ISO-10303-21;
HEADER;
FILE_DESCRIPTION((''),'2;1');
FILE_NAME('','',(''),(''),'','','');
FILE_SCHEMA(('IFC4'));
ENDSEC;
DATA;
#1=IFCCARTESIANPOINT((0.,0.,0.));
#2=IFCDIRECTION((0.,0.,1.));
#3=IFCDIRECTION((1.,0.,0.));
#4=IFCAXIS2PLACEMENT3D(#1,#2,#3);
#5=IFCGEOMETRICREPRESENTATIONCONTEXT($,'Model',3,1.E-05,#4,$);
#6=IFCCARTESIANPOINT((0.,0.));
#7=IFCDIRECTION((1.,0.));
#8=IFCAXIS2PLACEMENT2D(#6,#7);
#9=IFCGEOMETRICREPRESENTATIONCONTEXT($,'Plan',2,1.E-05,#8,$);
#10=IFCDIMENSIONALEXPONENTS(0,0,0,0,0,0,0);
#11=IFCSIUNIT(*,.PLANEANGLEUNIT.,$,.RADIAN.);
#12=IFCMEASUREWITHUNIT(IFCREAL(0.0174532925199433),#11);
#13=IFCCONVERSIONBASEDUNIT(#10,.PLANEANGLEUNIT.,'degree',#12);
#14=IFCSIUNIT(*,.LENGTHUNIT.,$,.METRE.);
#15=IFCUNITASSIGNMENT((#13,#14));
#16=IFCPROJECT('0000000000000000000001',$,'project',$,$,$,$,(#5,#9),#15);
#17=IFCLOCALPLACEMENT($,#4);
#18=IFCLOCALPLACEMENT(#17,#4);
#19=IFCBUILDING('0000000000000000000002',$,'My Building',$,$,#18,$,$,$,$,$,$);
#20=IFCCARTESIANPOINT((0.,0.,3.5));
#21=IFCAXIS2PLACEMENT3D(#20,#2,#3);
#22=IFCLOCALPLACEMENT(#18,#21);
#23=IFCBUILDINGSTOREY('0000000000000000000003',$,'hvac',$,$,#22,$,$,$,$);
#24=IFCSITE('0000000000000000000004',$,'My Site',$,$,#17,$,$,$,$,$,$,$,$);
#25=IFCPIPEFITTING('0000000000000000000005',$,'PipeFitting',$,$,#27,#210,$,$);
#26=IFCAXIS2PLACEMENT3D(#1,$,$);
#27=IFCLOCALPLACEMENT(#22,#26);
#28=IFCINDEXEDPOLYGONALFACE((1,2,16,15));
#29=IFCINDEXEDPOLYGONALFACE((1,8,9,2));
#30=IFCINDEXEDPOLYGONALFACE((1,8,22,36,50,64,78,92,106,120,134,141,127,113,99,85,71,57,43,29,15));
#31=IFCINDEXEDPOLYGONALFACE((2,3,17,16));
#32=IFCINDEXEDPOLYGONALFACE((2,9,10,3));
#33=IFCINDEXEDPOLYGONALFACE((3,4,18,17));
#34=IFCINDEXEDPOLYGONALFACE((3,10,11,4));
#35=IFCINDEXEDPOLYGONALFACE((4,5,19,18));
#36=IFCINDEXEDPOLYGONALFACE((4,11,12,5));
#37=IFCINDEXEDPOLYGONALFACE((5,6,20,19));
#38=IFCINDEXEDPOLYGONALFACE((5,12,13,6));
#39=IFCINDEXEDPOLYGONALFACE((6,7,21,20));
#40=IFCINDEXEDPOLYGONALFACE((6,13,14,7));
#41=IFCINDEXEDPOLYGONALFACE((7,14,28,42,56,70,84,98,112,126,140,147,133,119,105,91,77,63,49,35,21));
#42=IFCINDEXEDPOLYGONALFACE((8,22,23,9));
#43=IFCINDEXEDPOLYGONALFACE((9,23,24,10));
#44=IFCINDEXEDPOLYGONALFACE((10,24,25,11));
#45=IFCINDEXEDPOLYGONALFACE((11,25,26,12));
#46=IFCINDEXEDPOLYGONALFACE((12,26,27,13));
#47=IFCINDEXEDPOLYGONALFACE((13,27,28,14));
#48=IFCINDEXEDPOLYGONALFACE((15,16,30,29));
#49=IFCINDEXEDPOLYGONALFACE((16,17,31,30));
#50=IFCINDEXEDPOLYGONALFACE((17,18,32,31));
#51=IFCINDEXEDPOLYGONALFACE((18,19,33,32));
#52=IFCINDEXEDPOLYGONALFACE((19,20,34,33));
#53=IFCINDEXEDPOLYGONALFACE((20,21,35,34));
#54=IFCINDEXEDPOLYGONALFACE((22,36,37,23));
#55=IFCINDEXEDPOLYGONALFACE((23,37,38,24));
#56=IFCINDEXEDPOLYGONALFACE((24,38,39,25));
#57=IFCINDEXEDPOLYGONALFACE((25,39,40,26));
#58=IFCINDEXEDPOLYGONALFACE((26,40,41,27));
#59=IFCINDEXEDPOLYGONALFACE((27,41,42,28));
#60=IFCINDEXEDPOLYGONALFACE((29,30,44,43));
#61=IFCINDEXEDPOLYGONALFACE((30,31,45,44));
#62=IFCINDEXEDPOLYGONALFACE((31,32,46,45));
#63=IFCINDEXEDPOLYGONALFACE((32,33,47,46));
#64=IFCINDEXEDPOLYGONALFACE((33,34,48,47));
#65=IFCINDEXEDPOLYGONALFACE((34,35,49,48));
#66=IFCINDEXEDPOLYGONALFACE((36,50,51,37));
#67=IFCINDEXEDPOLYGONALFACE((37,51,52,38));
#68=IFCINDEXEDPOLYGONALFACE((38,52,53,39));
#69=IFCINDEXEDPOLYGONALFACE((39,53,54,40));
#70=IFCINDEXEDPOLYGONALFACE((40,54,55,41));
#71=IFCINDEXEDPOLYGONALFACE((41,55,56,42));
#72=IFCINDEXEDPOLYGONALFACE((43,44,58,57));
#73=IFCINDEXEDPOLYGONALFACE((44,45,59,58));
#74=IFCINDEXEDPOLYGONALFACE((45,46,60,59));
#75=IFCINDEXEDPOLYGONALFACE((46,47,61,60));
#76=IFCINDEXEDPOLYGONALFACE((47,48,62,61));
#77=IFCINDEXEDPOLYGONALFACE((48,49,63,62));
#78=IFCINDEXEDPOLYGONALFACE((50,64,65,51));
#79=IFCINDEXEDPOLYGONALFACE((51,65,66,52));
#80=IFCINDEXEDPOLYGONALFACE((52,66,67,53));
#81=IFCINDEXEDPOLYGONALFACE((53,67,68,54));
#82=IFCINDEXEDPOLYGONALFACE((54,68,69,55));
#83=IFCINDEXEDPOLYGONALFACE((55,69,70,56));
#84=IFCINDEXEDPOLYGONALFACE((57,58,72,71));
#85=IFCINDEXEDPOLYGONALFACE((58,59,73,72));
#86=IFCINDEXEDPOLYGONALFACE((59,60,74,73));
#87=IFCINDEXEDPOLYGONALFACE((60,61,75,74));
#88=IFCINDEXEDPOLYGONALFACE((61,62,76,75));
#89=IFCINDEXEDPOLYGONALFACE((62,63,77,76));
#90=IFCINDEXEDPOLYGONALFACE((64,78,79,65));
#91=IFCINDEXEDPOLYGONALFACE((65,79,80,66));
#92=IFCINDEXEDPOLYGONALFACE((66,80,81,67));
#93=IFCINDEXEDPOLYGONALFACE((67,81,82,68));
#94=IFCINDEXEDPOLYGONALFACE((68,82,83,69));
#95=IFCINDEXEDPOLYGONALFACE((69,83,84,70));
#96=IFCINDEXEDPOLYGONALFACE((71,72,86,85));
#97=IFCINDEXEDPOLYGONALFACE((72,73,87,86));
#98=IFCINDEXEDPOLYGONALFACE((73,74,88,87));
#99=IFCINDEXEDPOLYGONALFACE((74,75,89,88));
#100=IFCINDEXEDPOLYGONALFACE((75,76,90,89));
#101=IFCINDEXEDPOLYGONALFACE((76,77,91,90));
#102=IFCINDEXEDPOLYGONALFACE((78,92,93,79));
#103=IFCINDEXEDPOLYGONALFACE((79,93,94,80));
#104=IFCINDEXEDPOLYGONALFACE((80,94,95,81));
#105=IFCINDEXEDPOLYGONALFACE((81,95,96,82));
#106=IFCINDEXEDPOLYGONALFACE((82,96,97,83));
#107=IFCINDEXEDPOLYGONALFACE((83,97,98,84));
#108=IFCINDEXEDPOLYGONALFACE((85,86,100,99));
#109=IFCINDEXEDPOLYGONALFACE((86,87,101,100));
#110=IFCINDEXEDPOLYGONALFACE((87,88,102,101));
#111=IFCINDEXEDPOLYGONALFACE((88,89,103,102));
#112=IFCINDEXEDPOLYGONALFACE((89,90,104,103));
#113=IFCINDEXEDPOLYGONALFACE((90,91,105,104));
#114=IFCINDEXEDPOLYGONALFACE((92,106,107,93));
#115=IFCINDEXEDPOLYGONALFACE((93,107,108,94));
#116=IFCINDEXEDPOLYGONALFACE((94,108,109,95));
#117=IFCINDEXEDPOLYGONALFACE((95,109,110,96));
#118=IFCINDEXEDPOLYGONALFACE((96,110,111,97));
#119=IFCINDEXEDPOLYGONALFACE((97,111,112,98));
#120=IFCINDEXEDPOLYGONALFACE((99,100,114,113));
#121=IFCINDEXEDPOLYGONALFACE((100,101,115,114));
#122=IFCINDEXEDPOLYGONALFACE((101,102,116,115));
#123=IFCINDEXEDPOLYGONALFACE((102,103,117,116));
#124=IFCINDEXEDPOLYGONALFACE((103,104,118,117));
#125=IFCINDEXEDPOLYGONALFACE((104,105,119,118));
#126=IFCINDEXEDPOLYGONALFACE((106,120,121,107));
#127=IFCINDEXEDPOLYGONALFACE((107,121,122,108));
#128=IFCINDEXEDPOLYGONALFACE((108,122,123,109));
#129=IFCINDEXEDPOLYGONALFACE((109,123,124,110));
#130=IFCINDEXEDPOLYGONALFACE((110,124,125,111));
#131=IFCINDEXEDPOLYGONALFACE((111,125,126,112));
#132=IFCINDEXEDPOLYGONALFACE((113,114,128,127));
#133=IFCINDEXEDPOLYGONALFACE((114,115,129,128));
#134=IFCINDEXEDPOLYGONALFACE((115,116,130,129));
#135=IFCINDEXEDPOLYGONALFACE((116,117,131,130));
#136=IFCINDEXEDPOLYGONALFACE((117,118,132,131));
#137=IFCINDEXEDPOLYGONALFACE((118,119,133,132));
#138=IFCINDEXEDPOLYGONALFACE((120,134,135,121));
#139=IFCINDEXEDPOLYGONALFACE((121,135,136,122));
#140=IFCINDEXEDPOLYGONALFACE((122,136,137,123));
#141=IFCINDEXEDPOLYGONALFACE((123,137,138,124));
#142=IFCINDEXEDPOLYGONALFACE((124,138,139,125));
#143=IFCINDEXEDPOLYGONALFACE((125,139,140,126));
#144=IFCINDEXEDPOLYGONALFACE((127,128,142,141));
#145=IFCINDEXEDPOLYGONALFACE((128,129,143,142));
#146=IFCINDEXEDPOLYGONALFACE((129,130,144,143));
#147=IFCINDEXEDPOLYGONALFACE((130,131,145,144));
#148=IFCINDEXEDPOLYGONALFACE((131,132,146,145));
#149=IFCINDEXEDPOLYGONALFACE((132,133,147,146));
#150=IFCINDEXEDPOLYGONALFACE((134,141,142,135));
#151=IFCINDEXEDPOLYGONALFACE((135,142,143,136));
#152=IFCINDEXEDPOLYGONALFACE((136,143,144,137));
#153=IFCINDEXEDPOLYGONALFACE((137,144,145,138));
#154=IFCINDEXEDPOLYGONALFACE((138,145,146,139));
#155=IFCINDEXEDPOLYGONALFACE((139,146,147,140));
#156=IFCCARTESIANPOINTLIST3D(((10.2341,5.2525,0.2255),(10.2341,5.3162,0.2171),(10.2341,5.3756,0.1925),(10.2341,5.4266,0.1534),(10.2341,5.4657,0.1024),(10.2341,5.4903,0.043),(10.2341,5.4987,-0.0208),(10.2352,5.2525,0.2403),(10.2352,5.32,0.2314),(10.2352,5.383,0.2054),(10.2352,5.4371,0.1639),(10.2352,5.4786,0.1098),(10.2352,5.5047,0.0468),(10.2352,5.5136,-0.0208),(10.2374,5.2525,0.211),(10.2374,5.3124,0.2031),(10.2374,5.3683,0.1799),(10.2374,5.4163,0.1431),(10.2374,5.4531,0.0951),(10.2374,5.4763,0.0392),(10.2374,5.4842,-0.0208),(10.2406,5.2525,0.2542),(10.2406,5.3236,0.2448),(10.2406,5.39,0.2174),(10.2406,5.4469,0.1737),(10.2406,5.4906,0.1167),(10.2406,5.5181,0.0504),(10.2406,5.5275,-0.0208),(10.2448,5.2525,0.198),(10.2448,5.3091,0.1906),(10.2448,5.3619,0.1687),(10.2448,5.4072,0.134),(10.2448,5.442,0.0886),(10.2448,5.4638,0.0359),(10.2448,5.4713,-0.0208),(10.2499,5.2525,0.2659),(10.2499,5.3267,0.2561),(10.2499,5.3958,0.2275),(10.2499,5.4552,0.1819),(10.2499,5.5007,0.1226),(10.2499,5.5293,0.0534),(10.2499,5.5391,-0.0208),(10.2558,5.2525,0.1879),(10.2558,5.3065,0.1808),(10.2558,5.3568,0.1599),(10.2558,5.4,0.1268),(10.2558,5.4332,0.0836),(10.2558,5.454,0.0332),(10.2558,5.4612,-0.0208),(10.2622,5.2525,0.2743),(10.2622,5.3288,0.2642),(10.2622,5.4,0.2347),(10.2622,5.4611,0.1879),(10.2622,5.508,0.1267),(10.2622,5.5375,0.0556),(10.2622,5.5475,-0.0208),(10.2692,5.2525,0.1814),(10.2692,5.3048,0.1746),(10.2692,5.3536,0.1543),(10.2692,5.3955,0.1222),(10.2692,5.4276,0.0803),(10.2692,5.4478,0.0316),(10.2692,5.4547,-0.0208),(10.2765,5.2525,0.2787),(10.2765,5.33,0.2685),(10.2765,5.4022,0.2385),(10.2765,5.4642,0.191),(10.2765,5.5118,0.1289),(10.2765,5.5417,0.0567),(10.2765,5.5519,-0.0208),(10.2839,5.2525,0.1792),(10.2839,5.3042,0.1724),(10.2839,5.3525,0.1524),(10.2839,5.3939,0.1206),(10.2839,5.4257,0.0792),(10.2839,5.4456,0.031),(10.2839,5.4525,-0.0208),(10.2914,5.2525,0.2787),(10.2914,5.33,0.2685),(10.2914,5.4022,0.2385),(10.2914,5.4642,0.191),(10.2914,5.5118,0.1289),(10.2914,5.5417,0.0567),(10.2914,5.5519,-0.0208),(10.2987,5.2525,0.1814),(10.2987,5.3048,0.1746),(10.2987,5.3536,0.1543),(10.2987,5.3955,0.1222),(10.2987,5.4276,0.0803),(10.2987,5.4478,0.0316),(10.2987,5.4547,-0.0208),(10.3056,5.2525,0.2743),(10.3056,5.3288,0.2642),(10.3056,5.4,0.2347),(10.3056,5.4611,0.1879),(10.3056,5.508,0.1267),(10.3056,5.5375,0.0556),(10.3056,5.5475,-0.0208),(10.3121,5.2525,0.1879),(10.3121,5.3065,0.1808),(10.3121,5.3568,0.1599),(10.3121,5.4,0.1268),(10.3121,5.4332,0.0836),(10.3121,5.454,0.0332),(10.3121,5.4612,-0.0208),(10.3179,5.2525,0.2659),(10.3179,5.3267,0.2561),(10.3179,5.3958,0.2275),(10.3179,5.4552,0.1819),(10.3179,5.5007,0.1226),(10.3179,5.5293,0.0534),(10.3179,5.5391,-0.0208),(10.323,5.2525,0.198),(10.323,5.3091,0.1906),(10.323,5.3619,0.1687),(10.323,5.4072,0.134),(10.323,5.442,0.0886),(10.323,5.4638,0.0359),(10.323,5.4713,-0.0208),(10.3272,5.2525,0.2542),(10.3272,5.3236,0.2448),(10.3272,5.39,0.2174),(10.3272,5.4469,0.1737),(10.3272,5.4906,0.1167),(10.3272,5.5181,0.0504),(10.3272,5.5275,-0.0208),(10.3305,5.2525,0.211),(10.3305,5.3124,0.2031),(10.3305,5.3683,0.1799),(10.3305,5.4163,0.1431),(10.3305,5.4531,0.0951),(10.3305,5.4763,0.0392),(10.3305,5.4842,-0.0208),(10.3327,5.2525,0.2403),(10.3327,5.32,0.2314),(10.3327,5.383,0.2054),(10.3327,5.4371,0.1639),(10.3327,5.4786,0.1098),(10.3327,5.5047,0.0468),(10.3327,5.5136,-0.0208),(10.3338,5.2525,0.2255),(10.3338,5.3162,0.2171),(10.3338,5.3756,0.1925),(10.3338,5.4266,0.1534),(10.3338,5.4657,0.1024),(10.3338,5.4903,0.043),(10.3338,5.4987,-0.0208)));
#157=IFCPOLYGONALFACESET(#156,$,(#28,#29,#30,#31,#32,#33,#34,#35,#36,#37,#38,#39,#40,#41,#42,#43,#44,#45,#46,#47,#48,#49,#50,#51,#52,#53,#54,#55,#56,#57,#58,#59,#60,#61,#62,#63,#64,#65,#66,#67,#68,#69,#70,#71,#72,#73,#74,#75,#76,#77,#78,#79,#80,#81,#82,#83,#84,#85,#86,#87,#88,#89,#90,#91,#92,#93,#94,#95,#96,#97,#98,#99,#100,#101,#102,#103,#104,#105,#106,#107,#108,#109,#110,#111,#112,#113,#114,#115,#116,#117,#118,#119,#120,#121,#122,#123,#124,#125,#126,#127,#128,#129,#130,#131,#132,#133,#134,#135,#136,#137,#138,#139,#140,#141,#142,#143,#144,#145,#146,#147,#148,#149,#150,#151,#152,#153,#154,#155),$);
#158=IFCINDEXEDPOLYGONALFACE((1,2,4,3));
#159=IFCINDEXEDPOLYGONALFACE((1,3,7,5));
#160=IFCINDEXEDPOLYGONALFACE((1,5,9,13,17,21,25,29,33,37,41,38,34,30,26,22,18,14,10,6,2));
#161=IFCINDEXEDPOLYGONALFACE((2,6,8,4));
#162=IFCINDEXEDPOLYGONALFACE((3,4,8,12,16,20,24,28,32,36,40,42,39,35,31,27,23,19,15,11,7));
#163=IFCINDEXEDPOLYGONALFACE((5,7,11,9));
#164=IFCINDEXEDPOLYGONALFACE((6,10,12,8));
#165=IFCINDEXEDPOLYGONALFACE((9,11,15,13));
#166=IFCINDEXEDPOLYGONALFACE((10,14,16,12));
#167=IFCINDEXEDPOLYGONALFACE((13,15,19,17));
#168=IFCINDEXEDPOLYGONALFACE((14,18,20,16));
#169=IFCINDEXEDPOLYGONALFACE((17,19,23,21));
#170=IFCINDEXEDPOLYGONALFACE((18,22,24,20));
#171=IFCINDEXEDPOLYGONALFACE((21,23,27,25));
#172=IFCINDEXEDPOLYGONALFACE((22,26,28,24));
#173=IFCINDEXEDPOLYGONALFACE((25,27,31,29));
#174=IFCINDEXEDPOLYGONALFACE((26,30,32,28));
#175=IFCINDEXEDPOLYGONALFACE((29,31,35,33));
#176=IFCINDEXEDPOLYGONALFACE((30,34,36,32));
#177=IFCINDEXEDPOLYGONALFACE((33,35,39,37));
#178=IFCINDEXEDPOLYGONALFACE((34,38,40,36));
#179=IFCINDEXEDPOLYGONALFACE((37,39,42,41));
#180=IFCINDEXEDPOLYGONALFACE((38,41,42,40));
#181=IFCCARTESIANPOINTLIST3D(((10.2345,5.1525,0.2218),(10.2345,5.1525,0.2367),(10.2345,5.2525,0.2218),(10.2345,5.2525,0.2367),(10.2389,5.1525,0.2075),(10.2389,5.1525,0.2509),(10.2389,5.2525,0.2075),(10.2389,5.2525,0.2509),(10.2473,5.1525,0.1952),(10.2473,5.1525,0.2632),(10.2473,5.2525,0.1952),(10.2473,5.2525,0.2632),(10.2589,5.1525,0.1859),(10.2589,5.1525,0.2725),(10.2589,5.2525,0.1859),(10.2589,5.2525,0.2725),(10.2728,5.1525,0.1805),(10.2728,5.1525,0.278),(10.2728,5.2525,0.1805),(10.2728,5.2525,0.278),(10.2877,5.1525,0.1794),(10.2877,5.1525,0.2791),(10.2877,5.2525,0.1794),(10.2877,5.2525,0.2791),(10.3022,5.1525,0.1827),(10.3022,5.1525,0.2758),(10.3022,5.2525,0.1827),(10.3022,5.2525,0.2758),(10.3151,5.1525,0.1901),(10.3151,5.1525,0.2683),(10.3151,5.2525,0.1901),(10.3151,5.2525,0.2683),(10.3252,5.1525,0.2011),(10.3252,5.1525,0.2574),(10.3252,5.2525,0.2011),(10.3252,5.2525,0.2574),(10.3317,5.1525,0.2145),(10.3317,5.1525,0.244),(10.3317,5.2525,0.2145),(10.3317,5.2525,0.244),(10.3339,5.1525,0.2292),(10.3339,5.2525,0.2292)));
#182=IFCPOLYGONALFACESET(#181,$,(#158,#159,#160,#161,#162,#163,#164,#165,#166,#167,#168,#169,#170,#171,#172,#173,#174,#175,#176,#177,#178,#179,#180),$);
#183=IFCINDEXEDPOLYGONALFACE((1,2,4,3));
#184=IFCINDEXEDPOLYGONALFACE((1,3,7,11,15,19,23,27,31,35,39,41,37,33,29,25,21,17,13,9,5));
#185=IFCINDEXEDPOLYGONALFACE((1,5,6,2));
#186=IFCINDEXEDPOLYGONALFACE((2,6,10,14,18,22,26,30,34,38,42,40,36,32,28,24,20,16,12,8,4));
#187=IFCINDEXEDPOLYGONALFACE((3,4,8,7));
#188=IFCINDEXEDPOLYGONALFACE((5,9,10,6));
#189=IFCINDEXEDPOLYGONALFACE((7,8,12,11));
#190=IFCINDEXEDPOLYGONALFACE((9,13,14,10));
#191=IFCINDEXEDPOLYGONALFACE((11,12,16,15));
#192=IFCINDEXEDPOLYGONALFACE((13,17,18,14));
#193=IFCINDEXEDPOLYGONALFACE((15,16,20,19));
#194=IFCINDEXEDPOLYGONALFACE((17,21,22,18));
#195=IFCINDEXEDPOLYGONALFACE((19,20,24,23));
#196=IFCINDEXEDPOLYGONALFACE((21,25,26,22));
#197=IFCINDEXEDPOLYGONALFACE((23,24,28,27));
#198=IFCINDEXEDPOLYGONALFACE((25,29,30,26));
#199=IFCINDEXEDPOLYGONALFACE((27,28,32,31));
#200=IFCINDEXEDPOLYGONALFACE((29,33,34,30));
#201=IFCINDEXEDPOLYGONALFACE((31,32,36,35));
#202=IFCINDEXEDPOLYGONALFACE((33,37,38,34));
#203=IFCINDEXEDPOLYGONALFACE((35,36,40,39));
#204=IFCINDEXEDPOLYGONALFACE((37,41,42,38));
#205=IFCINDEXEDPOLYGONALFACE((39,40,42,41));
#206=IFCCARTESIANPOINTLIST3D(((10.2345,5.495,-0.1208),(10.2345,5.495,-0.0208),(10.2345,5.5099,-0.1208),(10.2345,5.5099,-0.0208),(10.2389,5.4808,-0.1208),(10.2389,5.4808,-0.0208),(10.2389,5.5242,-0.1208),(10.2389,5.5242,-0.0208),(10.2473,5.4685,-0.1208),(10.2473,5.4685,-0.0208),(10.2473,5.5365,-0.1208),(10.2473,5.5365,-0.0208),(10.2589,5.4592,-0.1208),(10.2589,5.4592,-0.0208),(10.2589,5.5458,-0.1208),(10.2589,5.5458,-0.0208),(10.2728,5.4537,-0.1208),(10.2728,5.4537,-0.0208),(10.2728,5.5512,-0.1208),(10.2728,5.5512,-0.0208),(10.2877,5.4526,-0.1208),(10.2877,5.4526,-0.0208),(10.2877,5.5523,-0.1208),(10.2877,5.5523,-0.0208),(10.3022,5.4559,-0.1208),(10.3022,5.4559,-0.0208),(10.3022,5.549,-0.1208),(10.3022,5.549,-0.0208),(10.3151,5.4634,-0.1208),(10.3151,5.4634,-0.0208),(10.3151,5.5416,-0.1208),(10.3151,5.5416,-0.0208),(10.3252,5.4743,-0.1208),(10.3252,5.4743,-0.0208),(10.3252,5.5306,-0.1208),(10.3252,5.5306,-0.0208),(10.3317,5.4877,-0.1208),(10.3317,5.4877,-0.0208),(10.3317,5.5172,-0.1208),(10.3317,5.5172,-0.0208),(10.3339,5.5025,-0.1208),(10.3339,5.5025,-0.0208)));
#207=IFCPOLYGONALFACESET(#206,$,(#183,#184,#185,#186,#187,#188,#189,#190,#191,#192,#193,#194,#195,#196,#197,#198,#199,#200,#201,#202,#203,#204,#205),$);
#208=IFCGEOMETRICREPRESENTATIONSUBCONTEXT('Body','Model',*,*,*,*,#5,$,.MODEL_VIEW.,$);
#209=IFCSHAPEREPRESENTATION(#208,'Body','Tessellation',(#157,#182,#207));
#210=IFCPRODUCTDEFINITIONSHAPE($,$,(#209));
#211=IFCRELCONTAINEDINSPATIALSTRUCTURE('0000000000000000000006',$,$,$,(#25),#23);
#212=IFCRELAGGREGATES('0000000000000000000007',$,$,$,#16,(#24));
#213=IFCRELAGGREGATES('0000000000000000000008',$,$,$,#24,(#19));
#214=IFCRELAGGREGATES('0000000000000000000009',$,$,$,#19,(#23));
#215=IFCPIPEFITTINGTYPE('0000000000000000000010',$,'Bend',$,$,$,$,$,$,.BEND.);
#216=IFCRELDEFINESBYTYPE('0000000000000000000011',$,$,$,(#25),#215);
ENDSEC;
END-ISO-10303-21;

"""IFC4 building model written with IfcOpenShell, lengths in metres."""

from ifc_helpers import new_model, entity, si_unit, converted_unit, frame, origin_with_axes, origin_2d_with_axis, place, context, subcontext, project, spatial, circle, extrude, source, transform, mapped, type_object, type_shapes, element, save


model = new_model("IFC4")

# Units and contexts
model_context = context("Model", 3, precision=1e-05, world=origin_with_axes())
plan_context = context("Plan", 2, precision=1e-05, world=origin_2d_with_axis())
body_context_1 = subcontext(model_context, "Body", "Model", "MODEL_VIEW")
ifc_project = project(units=[converted_unit("PLANEANGLEUNIT", "degree", entity("IfcReal", 0.0174532925199433), si_unit("PLANEANGLEUNIT", "RADIAN"), dimensions=[0, 0, 0, 0, 0, 0, 0]), si_unit("LENGTHUNIT", "METRE")], contexts=[model_context, plan_context])

# Site, building, storey
site_placement = place(None, origin_with_axes())
site = spatial("IfcSite", under=ifc_project, at=site_placement, Name="My Site")
building_placement = place(site_placement, origin_with_axes())
building = spatial("IfcBuilding", under=site, at=building_placement, Name="My Building")
storey_placement = place(building_placement, frame((0.0, 0.0, 3.5), z_axis=(0.0, 0.0, 1.0), x_axis=(1.0, 0.0, 0.0)))
storey = spatial("IfcBuildingStorey", under=building, at=storey_placement, Name="hvac")

# Pipe fitting
pipe_fitting_type = type_object("IfcPipeFittingType", Name="Bend", PredefinedType="BEND")
shared_shape_1 = source(origin_with_axes(), body_context_1, "Body", "SolidModel", [
    entity("IfcSweptDiskSolid", entity("IfcIndexedPolyCurve", entity("IfcCartesianPointList3D", [[0.0, 0.0, -0.1], [0.0, -0.0732, -0.2768], [0.0, -0.25, -0.35]]), [entity("IfcArcIndex", [1, 2, 3])]), 0.05),
    extrude(circle(Radius=0.05), origin_with_axes(), (0.0, 0.0, -1.0), 0.1),
    extrude(circle(Radius=0.05), frame((0.0, -0.25, -0.35), z_axis=(0.0, -1.0, -0.000032), x_axis=(1.0, 0.0, 0.0)), (0.0, 0.0, 1.0), 0.1),
])
type_shapes(pipe_fitting_type, [shared_shape_1])
for number, where, z_axis, x_axis, name in (
    (1, (10.2839, 5.1525, 0.2292), (0.0, -1.0, 0.0), (1.0, 0.0, 0.0), "PipeFitting"),
):
    element("IfcPipeFitting", number, at=place(storey_placement, frame(where, z_axis=z_axis, x_axis=x_axis)), inside=storey, type_object=pipe_fitting_type, Name=name, context=body_context_1, shape_type="MappedRepresentation", body=[
        mapped(shared_shape_1, transform((0.0, 0.0, 0.0), x_axis=(1.0, 0.0, 0.0), y_axis=(0.0, 1.0, 0.0), z_axis=(0.0, 0.0, 1.0), scale=1.0)),
    ])

save(model, "model.ifc")
